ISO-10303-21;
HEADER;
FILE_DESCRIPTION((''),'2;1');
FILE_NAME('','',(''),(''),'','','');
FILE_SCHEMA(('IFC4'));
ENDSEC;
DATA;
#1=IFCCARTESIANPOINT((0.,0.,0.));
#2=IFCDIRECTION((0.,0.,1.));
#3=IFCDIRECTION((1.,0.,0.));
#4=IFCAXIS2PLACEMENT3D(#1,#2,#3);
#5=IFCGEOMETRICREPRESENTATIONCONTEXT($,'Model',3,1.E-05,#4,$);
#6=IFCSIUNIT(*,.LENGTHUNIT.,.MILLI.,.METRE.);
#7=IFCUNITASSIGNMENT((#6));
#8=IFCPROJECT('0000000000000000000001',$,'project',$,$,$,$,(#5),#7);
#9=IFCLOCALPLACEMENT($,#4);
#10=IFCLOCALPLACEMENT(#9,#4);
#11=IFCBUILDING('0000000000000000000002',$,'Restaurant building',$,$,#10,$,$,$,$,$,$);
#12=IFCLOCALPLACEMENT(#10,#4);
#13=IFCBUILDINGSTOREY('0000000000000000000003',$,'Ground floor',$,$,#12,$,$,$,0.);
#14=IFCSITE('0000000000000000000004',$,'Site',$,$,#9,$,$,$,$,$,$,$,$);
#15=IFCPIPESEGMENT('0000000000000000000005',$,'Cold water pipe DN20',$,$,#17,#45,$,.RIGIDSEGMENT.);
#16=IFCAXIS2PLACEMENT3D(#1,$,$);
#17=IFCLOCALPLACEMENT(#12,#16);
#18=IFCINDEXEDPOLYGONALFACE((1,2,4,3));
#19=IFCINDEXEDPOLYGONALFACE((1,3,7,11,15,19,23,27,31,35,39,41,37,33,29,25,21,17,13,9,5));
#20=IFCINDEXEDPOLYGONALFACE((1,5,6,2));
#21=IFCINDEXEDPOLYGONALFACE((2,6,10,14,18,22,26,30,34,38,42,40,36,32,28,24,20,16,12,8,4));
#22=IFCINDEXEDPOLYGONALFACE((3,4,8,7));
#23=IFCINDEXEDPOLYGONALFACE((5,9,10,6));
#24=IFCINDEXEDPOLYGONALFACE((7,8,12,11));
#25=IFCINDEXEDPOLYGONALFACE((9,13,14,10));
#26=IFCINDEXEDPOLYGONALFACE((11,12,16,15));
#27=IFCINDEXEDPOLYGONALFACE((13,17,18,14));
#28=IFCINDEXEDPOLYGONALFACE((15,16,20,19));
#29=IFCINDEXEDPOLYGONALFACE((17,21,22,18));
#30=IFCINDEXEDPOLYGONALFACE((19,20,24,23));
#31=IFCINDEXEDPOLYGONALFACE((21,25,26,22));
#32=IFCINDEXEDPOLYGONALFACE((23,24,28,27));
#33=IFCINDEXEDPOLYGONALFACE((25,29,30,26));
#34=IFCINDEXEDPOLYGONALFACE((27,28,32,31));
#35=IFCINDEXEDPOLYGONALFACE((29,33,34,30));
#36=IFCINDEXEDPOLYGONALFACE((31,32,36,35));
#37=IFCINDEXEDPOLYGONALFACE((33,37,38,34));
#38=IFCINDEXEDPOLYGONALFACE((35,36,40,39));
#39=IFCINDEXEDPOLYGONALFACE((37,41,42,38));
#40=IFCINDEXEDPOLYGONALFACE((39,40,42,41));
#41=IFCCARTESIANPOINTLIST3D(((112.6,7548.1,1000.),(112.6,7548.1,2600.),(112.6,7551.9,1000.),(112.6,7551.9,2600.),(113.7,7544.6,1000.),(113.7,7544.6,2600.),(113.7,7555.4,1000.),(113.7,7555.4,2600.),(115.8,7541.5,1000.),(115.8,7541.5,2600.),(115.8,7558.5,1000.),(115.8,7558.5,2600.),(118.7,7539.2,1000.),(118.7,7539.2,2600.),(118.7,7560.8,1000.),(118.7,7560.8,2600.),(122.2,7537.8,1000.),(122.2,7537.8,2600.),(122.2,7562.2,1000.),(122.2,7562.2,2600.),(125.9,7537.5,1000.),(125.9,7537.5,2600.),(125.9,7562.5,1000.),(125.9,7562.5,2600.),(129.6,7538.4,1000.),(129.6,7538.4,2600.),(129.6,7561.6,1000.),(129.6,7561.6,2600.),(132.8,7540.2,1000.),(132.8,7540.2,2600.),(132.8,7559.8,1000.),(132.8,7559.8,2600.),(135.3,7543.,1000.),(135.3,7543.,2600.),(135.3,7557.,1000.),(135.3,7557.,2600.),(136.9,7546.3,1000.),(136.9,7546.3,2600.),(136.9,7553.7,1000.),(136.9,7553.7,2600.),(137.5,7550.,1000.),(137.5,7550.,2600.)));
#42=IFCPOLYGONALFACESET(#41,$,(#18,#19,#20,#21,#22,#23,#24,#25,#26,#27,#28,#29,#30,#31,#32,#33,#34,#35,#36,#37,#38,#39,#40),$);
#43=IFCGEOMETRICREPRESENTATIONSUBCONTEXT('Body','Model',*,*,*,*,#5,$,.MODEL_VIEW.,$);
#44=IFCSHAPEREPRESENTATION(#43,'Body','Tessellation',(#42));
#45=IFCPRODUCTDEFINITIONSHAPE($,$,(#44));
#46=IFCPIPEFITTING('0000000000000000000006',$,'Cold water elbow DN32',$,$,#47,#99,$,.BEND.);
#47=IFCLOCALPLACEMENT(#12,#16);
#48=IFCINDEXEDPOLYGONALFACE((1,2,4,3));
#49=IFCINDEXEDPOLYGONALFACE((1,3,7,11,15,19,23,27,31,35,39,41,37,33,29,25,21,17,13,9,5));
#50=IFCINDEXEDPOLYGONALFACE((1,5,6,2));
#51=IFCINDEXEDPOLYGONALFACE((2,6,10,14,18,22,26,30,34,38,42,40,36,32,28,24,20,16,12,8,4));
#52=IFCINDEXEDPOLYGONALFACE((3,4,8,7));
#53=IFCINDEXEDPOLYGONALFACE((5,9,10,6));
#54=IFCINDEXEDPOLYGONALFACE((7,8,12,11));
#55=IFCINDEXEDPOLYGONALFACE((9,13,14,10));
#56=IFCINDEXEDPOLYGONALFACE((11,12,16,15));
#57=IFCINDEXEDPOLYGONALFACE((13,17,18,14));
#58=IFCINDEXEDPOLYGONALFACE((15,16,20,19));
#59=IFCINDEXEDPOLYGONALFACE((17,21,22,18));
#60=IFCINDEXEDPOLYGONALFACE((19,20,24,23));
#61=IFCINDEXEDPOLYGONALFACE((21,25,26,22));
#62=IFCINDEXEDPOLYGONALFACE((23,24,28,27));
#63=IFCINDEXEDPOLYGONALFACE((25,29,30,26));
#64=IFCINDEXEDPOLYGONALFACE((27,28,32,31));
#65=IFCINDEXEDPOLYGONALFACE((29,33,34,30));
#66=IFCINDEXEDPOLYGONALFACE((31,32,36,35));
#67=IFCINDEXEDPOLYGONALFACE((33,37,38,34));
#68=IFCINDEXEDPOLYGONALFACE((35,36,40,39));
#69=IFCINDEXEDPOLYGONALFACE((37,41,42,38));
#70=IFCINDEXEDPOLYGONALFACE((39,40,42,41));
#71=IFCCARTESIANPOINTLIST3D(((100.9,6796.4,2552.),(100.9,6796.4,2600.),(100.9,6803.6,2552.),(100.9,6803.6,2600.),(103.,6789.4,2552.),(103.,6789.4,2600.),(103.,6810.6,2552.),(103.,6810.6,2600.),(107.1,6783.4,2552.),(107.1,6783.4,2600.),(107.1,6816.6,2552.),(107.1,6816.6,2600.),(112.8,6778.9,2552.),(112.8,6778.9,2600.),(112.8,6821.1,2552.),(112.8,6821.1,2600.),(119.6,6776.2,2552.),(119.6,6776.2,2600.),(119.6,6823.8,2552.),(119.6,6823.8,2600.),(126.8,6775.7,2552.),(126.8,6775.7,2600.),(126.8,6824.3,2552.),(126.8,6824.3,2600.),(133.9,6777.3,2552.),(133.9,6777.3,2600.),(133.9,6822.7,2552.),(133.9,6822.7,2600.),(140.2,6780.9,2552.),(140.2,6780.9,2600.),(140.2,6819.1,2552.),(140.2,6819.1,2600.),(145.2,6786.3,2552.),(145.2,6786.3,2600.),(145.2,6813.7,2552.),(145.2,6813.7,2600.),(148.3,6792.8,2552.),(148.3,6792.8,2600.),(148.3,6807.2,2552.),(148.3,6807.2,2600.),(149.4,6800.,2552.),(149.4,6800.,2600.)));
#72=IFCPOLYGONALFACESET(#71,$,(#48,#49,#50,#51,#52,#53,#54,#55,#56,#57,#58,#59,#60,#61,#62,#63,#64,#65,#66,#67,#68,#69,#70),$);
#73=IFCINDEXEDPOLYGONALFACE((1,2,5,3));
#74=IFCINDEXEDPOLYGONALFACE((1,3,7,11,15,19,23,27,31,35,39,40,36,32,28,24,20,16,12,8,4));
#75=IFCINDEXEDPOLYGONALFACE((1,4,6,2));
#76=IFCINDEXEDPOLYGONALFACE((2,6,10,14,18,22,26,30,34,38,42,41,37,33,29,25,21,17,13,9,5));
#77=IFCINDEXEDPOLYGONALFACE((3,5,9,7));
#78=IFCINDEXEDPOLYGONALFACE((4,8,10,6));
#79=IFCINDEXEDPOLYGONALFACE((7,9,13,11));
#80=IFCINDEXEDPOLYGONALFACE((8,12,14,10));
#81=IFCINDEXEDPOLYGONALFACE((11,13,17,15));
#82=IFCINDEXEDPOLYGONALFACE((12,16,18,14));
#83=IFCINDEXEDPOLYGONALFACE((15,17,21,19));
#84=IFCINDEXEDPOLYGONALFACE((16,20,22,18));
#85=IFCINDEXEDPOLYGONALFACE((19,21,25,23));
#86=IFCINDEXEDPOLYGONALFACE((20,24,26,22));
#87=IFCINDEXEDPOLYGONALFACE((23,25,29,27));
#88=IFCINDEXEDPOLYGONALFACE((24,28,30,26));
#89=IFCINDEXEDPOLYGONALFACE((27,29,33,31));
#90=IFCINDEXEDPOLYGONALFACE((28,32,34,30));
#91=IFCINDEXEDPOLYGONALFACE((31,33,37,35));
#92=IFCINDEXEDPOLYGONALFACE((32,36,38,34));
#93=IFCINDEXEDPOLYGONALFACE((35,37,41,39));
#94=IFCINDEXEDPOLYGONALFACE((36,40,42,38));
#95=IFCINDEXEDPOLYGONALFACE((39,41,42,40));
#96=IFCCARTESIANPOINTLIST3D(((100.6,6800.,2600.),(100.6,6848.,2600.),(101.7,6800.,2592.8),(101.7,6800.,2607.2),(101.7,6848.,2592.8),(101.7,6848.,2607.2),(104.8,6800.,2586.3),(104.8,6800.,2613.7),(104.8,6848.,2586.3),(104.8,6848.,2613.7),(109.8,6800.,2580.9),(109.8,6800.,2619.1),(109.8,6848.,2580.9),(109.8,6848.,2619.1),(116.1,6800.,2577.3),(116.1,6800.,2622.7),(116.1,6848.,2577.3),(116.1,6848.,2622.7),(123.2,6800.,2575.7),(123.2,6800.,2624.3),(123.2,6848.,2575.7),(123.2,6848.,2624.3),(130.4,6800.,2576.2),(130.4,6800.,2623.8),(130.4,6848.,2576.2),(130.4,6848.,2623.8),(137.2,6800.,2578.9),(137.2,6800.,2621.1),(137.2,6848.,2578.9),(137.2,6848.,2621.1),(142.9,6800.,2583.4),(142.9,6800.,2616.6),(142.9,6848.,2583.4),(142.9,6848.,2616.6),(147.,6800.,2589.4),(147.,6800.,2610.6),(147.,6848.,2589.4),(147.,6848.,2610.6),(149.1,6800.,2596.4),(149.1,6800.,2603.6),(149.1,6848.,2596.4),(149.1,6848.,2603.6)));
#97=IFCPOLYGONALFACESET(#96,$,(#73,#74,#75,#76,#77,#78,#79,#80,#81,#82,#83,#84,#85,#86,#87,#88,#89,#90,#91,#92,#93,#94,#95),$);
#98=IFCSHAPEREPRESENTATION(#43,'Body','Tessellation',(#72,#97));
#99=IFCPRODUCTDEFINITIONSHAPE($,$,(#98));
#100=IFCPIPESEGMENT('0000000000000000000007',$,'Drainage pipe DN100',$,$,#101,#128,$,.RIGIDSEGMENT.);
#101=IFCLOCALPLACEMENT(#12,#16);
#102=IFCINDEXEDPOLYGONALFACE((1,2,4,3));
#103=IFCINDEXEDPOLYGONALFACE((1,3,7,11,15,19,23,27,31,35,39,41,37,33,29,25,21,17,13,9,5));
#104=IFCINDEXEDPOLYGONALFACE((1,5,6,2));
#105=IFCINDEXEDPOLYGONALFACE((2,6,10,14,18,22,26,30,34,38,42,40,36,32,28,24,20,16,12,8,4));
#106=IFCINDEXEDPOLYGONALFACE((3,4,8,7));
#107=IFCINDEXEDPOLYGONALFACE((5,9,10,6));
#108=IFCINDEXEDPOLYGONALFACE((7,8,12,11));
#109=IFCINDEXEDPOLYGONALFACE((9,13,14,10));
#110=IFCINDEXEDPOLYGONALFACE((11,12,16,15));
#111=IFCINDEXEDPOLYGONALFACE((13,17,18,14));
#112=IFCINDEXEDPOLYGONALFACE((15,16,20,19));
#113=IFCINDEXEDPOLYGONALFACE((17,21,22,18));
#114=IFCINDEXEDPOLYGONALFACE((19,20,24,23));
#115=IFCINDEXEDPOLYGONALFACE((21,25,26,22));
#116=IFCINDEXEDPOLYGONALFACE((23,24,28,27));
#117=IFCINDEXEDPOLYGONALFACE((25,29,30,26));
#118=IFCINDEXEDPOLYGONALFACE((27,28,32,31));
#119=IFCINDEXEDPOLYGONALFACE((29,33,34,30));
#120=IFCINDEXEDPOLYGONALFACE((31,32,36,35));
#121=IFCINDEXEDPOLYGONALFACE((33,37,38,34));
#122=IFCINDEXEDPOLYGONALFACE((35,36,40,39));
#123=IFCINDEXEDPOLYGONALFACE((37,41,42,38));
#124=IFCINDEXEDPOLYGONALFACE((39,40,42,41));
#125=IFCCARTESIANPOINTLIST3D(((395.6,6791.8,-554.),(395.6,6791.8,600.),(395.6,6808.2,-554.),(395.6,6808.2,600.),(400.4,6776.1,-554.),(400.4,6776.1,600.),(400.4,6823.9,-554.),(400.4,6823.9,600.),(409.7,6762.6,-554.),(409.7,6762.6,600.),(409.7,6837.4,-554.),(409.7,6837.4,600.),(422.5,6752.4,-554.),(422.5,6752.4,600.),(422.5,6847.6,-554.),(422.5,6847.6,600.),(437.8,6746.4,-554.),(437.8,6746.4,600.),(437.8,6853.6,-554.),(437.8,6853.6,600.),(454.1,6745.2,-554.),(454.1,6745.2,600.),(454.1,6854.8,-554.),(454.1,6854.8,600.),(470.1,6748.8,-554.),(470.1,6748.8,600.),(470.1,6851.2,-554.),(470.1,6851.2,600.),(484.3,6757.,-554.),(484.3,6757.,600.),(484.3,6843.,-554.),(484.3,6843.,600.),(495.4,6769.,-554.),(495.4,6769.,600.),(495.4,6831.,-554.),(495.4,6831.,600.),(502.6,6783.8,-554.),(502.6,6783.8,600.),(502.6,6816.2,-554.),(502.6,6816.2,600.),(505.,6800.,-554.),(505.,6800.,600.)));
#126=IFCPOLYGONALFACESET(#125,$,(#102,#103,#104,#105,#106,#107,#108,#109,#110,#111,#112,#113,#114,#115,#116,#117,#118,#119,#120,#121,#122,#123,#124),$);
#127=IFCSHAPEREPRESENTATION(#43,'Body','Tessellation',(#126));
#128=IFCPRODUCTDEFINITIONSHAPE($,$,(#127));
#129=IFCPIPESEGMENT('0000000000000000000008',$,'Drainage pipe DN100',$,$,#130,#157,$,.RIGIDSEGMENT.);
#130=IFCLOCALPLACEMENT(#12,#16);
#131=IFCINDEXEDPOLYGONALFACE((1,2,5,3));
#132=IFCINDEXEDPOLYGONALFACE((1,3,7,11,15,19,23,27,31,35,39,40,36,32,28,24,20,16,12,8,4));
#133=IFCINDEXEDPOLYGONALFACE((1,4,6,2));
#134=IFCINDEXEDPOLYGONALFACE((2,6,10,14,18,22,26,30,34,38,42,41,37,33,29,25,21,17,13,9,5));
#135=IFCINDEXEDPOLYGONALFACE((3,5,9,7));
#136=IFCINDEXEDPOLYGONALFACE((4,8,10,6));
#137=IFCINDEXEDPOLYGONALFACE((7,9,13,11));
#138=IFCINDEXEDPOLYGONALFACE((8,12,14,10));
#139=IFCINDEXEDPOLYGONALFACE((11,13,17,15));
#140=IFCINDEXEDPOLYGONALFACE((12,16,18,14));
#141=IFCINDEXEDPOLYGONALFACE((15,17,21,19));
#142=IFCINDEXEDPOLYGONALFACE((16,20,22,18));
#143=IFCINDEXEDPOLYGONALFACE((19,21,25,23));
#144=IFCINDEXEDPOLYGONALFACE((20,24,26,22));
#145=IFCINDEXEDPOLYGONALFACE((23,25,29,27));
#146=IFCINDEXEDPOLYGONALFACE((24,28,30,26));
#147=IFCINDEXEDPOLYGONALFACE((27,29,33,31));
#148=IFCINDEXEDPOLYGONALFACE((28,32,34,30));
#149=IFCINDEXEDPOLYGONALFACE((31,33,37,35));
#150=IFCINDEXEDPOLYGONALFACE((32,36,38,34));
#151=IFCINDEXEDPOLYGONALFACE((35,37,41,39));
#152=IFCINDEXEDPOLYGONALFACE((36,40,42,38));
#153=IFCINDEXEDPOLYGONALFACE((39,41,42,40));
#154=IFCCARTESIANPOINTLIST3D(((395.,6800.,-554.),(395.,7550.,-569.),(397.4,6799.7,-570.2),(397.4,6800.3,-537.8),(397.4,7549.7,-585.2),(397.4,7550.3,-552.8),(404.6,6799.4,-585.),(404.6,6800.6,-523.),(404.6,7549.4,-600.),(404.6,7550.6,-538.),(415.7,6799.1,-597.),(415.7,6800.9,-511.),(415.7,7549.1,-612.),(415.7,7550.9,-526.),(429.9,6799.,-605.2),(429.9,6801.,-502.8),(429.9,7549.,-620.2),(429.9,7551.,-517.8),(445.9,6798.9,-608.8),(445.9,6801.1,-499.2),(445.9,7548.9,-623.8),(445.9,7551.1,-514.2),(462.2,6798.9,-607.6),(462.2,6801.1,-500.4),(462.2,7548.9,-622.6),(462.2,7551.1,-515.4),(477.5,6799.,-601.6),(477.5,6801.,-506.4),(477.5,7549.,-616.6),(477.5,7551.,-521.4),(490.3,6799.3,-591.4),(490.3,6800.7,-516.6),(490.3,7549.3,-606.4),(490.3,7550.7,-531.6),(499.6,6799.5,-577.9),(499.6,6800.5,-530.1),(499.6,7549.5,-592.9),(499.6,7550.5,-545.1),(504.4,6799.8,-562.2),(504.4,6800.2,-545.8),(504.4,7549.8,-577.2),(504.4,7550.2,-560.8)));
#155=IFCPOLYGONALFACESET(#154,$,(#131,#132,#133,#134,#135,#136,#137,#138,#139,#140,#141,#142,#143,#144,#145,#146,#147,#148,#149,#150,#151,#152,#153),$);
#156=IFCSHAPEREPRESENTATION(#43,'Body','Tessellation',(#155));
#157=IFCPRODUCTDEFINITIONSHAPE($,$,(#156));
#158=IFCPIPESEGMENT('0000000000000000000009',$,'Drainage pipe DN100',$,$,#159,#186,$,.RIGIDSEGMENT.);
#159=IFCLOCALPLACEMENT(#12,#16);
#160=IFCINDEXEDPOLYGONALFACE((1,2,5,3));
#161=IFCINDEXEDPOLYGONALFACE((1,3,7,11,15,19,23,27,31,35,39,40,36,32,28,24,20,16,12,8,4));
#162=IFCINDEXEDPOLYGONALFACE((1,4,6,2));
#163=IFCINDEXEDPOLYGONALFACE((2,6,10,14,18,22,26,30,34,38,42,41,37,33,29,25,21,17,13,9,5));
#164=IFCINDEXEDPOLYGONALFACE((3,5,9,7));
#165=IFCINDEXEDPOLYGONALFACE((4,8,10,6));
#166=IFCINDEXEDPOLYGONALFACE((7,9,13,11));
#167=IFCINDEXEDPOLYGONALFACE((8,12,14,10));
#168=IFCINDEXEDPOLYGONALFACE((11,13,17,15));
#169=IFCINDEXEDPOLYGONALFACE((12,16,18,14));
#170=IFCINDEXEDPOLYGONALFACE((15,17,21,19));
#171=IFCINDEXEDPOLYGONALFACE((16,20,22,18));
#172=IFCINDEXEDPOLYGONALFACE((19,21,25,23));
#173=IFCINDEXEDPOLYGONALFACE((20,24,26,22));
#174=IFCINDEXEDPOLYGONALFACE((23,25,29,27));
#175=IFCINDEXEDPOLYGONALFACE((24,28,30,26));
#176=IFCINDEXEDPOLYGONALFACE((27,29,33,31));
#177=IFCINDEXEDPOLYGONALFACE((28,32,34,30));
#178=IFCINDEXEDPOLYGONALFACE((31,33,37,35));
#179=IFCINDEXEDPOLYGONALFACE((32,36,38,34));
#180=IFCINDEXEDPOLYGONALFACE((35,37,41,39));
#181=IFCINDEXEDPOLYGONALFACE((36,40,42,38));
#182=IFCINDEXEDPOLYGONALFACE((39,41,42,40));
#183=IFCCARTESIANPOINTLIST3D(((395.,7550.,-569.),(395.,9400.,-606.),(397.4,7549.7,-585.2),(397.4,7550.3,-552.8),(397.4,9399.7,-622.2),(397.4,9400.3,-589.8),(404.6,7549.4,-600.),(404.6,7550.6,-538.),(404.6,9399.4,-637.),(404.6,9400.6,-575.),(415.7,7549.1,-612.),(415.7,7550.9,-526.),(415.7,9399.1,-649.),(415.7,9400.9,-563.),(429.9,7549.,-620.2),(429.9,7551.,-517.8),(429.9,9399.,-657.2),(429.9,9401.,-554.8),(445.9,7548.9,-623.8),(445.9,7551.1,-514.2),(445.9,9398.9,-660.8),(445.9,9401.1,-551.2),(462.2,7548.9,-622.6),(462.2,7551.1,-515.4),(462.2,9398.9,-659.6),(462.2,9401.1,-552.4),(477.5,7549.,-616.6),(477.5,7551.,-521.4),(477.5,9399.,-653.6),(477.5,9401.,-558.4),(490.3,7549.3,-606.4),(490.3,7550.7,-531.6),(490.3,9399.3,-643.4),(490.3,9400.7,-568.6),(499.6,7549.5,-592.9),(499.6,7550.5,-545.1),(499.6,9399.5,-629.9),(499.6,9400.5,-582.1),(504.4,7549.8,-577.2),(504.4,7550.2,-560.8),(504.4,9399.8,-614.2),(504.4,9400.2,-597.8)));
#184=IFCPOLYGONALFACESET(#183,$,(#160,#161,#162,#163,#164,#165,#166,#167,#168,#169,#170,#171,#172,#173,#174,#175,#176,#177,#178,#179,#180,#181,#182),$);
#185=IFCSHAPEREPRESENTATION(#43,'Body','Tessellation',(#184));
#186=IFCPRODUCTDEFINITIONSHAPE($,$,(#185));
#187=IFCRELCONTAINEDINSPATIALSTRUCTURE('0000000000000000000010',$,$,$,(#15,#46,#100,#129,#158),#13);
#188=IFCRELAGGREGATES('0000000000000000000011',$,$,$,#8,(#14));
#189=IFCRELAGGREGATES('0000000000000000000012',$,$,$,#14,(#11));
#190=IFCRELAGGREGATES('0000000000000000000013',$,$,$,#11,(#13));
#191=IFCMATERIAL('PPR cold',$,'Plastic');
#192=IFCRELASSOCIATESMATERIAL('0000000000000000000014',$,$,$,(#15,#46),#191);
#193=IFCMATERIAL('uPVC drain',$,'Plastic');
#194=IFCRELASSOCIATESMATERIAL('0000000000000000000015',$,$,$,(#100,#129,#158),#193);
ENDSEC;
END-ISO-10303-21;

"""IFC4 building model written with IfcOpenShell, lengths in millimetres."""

from ifc_helpers import new_model, si_unit, frame, origin_with_axes, origin_2d, place, context, subcontext, project, spatial, circle, extrude, material, element, save


model = new_model("IFC4")

# Units and contexts
model_context = context("Model", 3, precision=1e-05, world=origin_with_axes())
body_context = subcontext(model_context, "Body", "Model", "MODEL_VIEW")
ifc_project = project(units=[si_unit("LENGTHUNIT", "METRE", prefix="MILLI")], contexts=[model_context])

# Site, building, storey
site_placement = place(None, origin_with_axes())
site = spatial("IfcSite", under=ifc_project, at=site_placement, Name="Site")
building_placement = place(site_placement, origin_with_axes())
building = spatial("IfcBuilding", under=site, at=building_placement, Name="Restaurant building")
storey_placement = place(building_placement, origin_with_axes())
storey = spatial("IfcBuildingStorey", under=building, at=storey_placement, Name="Ground floor", Elevation=0.0)

# Pipe segment
ifc_material_1 = material(Name="PPR cold", Category="Plastic")
pipe_segment_1_placement = place(storey_placement, frame((125.0, 7550.0, 2600.0)))
element("IfcPipeSegment", 1, at=pipe_segment_1_placement, inside=storey, material=ifc_material_1, Name="Cold water pipe DN20", PredefinedType="RIGIDSEGMENT", context=body_context, shape_type="SweptSolid", body=[
    extrude(circle(Radius=12.5, at=origin_2d()), frame((0.0, 0.0, 0.0), z_axis=(0.0, 0.0, -1.0), x_axis=(1.0, 0.0, 0.0)), (0.0, 0.0, 1.0), 1600.0),
])

# Pipe fitting
pipe_fitting_1_placement = place(storey_placement, frame((125.0, 6800.0, 2600.0)))
element("IfcPipeFitting", 2, at=pipe_fitting_1_placement, inside=storey, material=ifc_material_1, Name="Cold water elbow DN32", PredefinedType="BEND", context=body_context, shape_type="SweptSolid", body=[
    extrude(circle(Radius=24.4, at=origin_2d()), frame((0.0, 0.0, 0.0), z_axis=(0.0, 0.0, -1.0), x_axis=(1.0, 0.0, 0.0)), (0.0, 0.0, 1.0), 48.0),
    extrude(circle(Radius=24.4, at=origin_2d()), frame((0.0, 0.0, 0.0), z_axis=(0.0, 1.0, 0.0), x_axis=(-1.0, 0.0, 0.0)), (0.0, 0.0, 1.0), 48.0),
])

# Pipe segments
ifc_material_2 = material(Name="uPVC drain", Category="Plastic")
pipe_segment_2_placement = place(storey_placement, frame((450.0, 6800.0, 600.0)))
element("IfcPipeSegment", 3, at=pipe_segment_2_placement, inside=storey, material=ifc_material_2, Name="Drainage pipe DN100", PredefinedType="RIGIDSEGMENT", context=body_context, shape_type="SweptSolid", body=[
    extrude(circle(Radius=55.0, at=origin_2d()), frame((0.0, 0.0, 0.0), z_axis=(0.0, 0.0, -1.0), x_axis=(1.0, 0.0, 0.0)), (0.0, 0.0, 1.0), 1154.0),
])
pipe_segment_3_placement = place(storey_placement, frame((450.0, 6800.0, -554.0)))
element("IfcPipeSegment", 4, at=pipe_segment_3_placement, inside=storey, material=ifc_material_2, Name="Drainage pipe DN100", PredefinedType="RIGIDSEGMENT", context=body_context, shape_type="SweptSolid", body=[
    extrude(circle(Radius=55.0, at=origin_2d()), frame((0.0, 0.0, 0.0), z_axis=(0.0, 0.9998, -0.019996), x_axis=(-1.0, 0.0, 0.0)), (0.0, 0.0, 1.0), 750.1),
])
pipe_segment_4_placement = place(storey_placement, frame((450.0, 7550.0, -569.0)))
element("IfcPipeSegment", 5, at=pipe_segment_4_placement, inside=storey, material=ifc_material_2, Name="Drainage pipe DN100", PredefinedType="RIGIDSEGMENT", context=body_context, shape_type="SweptSolid", body=[
    extrude(circle(Radius=55.0, at=origin_2d()), frame((0.0, 0.0, 0.0), z_axis=(0.0, 0.9998, -0.019996), x_axis=(-1.0, 0.0, 0.0)), (0.0, 0.0, 1.0), 1850.4),
])

save(model, "model.ifc")
